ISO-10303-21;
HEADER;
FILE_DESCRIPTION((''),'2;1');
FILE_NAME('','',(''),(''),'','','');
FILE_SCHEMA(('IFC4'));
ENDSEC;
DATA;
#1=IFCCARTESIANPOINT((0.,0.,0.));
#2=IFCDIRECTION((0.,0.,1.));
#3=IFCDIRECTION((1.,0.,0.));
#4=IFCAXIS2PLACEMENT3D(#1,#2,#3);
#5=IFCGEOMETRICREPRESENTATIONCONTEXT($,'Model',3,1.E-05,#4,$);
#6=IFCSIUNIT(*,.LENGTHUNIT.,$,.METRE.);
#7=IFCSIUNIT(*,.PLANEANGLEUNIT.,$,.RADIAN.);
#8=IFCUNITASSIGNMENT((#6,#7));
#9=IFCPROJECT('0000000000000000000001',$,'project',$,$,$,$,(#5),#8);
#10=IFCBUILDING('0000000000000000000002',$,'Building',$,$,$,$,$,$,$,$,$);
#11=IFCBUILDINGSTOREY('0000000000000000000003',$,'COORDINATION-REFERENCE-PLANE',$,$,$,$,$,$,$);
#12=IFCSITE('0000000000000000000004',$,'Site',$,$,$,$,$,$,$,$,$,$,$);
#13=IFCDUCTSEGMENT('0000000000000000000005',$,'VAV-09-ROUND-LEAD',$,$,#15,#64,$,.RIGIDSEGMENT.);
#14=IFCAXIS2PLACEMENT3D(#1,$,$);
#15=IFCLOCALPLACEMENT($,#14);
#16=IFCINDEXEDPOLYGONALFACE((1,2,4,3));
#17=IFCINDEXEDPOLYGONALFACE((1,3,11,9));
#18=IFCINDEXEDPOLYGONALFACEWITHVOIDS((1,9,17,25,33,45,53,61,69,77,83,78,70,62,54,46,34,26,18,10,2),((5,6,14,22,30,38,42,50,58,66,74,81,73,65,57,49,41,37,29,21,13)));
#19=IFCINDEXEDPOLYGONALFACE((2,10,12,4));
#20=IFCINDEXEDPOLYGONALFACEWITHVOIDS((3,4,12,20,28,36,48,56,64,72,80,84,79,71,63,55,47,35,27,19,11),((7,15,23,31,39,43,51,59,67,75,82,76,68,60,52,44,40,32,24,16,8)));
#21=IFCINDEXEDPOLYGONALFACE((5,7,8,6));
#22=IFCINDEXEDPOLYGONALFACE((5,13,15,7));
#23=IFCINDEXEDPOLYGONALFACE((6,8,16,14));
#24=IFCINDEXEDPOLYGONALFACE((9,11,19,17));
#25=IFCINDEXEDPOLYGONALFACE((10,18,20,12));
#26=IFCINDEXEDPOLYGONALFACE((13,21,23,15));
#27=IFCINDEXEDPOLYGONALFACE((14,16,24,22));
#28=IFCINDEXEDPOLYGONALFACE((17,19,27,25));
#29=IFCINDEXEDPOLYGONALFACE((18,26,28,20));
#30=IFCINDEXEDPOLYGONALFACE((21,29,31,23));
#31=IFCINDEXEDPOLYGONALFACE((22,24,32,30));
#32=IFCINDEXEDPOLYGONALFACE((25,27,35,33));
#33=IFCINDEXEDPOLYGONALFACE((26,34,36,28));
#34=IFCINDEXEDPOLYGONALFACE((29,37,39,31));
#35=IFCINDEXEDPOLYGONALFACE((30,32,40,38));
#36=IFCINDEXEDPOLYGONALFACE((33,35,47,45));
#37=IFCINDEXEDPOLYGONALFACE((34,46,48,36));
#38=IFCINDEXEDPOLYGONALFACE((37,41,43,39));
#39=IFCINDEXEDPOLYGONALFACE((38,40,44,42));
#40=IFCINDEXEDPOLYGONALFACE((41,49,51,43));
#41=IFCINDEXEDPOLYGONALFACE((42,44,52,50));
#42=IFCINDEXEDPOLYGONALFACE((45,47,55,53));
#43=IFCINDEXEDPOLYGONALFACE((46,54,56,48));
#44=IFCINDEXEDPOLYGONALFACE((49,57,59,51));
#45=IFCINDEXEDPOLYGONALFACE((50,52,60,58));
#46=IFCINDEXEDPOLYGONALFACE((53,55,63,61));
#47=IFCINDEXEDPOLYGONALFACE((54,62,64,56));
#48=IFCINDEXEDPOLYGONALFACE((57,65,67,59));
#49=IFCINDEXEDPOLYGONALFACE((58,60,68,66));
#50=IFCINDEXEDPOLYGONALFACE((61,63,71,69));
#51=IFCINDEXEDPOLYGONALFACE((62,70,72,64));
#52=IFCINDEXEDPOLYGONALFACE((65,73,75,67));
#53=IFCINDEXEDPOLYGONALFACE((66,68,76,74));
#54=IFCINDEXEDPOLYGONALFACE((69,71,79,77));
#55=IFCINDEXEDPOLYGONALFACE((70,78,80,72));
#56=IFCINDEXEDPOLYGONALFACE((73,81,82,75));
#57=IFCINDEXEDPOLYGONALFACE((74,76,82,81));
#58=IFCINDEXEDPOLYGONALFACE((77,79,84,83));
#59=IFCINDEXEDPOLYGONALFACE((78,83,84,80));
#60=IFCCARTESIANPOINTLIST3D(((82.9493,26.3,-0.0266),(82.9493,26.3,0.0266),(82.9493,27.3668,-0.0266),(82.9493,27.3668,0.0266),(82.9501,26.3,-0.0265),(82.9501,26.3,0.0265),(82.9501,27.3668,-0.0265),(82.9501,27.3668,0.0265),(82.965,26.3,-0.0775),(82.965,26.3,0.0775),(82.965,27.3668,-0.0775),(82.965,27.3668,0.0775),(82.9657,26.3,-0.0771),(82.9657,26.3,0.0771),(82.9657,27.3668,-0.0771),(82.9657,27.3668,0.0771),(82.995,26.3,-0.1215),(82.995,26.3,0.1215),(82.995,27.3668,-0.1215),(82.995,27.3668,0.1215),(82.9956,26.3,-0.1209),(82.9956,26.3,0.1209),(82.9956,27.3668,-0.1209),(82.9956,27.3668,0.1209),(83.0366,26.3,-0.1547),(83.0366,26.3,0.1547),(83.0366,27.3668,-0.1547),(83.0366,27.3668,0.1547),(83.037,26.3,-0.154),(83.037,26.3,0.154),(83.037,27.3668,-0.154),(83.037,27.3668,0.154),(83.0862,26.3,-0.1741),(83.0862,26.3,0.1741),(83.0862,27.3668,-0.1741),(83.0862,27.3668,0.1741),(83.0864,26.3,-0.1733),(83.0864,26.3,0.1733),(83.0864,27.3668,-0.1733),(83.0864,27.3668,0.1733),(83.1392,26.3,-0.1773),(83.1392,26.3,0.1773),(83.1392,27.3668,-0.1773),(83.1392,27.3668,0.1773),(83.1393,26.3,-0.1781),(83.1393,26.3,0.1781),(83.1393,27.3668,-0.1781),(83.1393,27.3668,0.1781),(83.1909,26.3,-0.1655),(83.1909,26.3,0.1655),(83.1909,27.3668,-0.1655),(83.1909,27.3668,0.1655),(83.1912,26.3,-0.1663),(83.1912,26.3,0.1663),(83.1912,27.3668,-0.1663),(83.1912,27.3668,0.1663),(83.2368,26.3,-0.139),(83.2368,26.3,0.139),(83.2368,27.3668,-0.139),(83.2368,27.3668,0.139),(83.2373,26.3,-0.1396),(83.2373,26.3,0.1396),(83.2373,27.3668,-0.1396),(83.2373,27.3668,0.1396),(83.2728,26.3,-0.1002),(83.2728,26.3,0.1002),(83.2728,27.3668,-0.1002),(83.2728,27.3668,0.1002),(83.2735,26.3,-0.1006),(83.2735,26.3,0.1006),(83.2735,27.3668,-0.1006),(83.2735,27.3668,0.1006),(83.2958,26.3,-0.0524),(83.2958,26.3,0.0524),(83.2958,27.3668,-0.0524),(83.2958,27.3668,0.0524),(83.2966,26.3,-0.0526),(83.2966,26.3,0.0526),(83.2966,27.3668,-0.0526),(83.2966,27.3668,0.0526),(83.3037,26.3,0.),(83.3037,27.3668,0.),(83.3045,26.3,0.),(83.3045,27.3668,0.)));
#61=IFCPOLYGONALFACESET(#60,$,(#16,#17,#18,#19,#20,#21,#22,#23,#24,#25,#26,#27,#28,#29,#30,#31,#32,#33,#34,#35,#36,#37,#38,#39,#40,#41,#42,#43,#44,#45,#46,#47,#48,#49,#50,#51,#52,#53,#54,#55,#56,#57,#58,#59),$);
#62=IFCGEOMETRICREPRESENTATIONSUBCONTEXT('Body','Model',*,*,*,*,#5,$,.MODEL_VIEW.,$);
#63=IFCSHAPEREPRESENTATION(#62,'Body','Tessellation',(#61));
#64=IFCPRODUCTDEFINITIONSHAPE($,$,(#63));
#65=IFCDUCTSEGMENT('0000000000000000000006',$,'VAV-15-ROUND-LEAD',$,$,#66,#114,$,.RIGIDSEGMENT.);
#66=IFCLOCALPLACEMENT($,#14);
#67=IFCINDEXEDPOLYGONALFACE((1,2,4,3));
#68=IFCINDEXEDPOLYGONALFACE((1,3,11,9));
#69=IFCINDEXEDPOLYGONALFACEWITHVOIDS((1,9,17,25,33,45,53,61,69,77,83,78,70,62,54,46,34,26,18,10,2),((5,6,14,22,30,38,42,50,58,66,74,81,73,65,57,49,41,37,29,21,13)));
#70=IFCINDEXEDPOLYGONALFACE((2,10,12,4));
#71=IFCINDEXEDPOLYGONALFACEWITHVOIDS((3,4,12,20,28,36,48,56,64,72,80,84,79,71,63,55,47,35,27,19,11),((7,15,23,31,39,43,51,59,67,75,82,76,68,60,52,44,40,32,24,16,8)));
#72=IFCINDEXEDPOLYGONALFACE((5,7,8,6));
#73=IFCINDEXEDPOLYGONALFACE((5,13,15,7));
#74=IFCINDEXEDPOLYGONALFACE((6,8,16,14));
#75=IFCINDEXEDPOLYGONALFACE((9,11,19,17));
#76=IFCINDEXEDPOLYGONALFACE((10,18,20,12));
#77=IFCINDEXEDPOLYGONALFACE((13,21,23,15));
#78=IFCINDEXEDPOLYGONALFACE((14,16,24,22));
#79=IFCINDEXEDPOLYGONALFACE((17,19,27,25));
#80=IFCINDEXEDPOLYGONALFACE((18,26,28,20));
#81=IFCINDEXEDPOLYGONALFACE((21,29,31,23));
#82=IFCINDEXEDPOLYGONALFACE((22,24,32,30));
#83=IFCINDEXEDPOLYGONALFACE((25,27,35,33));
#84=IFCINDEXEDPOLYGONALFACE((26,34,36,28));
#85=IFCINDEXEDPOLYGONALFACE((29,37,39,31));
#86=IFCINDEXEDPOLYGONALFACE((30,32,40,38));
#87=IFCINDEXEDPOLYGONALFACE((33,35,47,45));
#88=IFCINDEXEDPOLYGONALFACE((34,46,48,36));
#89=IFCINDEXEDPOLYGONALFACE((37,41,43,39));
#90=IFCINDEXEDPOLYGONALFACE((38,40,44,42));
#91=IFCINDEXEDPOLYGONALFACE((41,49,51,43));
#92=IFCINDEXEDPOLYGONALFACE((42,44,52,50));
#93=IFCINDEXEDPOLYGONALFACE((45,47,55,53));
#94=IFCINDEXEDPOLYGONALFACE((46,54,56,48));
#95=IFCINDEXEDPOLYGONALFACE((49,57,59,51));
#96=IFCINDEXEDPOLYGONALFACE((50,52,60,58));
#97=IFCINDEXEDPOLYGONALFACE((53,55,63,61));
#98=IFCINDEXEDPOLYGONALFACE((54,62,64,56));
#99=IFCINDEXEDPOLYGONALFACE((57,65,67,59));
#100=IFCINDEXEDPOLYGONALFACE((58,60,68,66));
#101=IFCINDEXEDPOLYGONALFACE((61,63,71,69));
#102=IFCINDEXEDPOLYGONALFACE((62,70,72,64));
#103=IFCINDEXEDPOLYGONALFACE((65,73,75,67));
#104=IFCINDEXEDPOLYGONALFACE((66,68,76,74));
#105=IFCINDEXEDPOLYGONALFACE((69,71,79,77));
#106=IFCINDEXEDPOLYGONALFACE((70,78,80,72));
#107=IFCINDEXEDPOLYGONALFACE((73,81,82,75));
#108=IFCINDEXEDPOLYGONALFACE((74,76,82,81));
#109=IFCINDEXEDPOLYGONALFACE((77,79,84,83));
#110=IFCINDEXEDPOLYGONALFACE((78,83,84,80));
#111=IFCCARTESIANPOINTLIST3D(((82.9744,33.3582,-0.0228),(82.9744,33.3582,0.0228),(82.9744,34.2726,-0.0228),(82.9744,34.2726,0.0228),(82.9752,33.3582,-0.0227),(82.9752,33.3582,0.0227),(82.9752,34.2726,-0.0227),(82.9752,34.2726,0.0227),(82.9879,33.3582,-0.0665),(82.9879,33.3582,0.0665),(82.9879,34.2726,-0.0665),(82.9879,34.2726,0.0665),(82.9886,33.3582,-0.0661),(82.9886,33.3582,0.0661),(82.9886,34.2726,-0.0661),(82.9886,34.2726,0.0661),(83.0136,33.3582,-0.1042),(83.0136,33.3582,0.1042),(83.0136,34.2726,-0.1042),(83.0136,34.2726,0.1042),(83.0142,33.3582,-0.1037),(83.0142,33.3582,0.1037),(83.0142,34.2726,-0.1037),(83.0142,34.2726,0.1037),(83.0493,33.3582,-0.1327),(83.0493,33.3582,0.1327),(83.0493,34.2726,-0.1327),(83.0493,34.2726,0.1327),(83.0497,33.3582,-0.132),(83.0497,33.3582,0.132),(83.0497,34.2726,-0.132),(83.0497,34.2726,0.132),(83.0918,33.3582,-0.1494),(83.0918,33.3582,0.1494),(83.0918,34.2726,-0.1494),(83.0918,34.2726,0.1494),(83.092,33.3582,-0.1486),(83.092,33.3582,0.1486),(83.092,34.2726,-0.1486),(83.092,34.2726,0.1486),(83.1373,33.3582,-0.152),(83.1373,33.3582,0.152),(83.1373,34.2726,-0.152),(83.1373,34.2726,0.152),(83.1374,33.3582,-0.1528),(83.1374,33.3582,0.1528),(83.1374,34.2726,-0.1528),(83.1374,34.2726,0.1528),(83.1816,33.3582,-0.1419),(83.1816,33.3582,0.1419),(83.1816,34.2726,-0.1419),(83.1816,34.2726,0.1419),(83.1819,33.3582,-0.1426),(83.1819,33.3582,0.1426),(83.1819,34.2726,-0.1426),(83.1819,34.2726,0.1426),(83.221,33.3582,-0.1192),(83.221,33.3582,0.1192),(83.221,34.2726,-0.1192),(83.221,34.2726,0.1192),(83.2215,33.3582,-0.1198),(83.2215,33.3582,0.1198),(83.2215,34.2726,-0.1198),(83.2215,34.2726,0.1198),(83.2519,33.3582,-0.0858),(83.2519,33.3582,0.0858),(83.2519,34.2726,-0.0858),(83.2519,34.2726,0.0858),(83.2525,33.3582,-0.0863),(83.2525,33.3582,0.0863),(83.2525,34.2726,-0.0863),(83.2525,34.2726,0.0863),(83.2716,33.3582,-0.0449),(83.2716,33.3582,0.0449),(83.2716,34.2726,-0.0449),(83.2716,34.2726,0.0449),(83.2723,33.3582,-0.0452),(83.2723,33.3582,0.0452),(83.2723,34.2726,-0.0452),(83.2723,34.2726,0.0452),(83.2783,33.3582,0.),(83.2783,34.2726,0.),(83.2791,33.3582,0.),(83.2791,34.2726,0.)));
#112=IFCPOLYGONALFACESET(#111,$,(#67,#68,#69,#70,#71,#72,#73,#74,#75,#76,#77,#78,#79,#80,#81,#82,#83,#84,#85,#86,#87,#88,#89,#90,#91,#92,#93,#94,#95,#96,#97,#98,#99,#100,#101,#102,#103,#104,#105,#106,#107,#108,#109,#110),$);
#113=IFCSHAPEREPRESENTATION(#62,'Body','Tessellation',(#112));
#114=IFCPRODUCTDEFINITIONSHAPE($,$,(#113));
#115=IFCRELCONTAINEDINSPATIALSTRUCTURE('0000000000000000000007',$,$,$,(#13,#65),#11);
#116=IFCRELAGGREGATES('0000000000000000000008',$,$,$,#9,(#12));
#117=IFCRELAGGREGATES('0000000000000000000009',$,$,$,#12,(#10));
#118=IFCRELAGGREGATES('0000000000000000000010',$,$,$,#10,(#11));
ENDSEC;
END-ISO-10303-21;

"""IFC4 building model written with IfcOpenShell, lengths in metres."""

from ifc_helpers import new_model, si_unit, frame, origin, origin_with_axes, place, context, subcontext, project, spatial, hollow_circle, extrude, element, save


model = new_model("IFC4")

# Units and contexts
model_context = context("Model", 3, precision=1e-05, world=origin_with_axes())
body_context_1 = subcontext(model_context, "Body", "Model", "MODEL_VIEW")
ifc_project = project(units=[si_unit("LENGTHUNIT", "METRE"), si_unit("PLANEANGLEUNIT", "RADIAN")], contexts=[model_context])

# Site, building, storey
site = spatial("IfcSite", under=ifc_project, Name="Site")
building = spatial("IfcBuilding", under=site, Name="Building")
storey = spatial("IfcBuildingStorey", under=building, Name="COORDINATION-REFERENCE-PLANE")

# Duct segments
duct_segment_1_placement = place(None, frame((83.1259, 27.3668, 0.0), z_axis=(0.0, -1.0, 0.0), x_axis=(1.0, 0.0, 0.0)))
element("IfcDuctSegment", 1, at=duct_segment_1_placement, inside=storey, Name="VAV-09-ROUND-LEAD", PredefinedType="RIGIDSEGMENT", context=body_context_1, shape_type="SweptSolid", body=[
    extrude(hollow_circle(Radius=0.1786, WallThickness=0.0008), origin(), (0.0, 0.0, 1.0), 1.0668),
])
duct_segment_2_placement = place(None, frame((83.1259, 34.2726, 0.0), z_axis=(0.0, -1.0, 0.0), x_axis=(1.0, 0.0, 0.0)))
element("IfcDuctSegment", 2, at=duct_segment_2_placement, inside=storey, Name="VAV-15-ROUND-LEAD", PredefinedType="RIGIDSEGMENT", context=body_context_1, shape_type="SweptSolid", body=[
    extrude(hollow_circle(Radius=0.1532, WallThickness=0.0008), origin(), (0.0, 0.0, 1.0), 0.9144),
])

save(model, "model.ifc")
